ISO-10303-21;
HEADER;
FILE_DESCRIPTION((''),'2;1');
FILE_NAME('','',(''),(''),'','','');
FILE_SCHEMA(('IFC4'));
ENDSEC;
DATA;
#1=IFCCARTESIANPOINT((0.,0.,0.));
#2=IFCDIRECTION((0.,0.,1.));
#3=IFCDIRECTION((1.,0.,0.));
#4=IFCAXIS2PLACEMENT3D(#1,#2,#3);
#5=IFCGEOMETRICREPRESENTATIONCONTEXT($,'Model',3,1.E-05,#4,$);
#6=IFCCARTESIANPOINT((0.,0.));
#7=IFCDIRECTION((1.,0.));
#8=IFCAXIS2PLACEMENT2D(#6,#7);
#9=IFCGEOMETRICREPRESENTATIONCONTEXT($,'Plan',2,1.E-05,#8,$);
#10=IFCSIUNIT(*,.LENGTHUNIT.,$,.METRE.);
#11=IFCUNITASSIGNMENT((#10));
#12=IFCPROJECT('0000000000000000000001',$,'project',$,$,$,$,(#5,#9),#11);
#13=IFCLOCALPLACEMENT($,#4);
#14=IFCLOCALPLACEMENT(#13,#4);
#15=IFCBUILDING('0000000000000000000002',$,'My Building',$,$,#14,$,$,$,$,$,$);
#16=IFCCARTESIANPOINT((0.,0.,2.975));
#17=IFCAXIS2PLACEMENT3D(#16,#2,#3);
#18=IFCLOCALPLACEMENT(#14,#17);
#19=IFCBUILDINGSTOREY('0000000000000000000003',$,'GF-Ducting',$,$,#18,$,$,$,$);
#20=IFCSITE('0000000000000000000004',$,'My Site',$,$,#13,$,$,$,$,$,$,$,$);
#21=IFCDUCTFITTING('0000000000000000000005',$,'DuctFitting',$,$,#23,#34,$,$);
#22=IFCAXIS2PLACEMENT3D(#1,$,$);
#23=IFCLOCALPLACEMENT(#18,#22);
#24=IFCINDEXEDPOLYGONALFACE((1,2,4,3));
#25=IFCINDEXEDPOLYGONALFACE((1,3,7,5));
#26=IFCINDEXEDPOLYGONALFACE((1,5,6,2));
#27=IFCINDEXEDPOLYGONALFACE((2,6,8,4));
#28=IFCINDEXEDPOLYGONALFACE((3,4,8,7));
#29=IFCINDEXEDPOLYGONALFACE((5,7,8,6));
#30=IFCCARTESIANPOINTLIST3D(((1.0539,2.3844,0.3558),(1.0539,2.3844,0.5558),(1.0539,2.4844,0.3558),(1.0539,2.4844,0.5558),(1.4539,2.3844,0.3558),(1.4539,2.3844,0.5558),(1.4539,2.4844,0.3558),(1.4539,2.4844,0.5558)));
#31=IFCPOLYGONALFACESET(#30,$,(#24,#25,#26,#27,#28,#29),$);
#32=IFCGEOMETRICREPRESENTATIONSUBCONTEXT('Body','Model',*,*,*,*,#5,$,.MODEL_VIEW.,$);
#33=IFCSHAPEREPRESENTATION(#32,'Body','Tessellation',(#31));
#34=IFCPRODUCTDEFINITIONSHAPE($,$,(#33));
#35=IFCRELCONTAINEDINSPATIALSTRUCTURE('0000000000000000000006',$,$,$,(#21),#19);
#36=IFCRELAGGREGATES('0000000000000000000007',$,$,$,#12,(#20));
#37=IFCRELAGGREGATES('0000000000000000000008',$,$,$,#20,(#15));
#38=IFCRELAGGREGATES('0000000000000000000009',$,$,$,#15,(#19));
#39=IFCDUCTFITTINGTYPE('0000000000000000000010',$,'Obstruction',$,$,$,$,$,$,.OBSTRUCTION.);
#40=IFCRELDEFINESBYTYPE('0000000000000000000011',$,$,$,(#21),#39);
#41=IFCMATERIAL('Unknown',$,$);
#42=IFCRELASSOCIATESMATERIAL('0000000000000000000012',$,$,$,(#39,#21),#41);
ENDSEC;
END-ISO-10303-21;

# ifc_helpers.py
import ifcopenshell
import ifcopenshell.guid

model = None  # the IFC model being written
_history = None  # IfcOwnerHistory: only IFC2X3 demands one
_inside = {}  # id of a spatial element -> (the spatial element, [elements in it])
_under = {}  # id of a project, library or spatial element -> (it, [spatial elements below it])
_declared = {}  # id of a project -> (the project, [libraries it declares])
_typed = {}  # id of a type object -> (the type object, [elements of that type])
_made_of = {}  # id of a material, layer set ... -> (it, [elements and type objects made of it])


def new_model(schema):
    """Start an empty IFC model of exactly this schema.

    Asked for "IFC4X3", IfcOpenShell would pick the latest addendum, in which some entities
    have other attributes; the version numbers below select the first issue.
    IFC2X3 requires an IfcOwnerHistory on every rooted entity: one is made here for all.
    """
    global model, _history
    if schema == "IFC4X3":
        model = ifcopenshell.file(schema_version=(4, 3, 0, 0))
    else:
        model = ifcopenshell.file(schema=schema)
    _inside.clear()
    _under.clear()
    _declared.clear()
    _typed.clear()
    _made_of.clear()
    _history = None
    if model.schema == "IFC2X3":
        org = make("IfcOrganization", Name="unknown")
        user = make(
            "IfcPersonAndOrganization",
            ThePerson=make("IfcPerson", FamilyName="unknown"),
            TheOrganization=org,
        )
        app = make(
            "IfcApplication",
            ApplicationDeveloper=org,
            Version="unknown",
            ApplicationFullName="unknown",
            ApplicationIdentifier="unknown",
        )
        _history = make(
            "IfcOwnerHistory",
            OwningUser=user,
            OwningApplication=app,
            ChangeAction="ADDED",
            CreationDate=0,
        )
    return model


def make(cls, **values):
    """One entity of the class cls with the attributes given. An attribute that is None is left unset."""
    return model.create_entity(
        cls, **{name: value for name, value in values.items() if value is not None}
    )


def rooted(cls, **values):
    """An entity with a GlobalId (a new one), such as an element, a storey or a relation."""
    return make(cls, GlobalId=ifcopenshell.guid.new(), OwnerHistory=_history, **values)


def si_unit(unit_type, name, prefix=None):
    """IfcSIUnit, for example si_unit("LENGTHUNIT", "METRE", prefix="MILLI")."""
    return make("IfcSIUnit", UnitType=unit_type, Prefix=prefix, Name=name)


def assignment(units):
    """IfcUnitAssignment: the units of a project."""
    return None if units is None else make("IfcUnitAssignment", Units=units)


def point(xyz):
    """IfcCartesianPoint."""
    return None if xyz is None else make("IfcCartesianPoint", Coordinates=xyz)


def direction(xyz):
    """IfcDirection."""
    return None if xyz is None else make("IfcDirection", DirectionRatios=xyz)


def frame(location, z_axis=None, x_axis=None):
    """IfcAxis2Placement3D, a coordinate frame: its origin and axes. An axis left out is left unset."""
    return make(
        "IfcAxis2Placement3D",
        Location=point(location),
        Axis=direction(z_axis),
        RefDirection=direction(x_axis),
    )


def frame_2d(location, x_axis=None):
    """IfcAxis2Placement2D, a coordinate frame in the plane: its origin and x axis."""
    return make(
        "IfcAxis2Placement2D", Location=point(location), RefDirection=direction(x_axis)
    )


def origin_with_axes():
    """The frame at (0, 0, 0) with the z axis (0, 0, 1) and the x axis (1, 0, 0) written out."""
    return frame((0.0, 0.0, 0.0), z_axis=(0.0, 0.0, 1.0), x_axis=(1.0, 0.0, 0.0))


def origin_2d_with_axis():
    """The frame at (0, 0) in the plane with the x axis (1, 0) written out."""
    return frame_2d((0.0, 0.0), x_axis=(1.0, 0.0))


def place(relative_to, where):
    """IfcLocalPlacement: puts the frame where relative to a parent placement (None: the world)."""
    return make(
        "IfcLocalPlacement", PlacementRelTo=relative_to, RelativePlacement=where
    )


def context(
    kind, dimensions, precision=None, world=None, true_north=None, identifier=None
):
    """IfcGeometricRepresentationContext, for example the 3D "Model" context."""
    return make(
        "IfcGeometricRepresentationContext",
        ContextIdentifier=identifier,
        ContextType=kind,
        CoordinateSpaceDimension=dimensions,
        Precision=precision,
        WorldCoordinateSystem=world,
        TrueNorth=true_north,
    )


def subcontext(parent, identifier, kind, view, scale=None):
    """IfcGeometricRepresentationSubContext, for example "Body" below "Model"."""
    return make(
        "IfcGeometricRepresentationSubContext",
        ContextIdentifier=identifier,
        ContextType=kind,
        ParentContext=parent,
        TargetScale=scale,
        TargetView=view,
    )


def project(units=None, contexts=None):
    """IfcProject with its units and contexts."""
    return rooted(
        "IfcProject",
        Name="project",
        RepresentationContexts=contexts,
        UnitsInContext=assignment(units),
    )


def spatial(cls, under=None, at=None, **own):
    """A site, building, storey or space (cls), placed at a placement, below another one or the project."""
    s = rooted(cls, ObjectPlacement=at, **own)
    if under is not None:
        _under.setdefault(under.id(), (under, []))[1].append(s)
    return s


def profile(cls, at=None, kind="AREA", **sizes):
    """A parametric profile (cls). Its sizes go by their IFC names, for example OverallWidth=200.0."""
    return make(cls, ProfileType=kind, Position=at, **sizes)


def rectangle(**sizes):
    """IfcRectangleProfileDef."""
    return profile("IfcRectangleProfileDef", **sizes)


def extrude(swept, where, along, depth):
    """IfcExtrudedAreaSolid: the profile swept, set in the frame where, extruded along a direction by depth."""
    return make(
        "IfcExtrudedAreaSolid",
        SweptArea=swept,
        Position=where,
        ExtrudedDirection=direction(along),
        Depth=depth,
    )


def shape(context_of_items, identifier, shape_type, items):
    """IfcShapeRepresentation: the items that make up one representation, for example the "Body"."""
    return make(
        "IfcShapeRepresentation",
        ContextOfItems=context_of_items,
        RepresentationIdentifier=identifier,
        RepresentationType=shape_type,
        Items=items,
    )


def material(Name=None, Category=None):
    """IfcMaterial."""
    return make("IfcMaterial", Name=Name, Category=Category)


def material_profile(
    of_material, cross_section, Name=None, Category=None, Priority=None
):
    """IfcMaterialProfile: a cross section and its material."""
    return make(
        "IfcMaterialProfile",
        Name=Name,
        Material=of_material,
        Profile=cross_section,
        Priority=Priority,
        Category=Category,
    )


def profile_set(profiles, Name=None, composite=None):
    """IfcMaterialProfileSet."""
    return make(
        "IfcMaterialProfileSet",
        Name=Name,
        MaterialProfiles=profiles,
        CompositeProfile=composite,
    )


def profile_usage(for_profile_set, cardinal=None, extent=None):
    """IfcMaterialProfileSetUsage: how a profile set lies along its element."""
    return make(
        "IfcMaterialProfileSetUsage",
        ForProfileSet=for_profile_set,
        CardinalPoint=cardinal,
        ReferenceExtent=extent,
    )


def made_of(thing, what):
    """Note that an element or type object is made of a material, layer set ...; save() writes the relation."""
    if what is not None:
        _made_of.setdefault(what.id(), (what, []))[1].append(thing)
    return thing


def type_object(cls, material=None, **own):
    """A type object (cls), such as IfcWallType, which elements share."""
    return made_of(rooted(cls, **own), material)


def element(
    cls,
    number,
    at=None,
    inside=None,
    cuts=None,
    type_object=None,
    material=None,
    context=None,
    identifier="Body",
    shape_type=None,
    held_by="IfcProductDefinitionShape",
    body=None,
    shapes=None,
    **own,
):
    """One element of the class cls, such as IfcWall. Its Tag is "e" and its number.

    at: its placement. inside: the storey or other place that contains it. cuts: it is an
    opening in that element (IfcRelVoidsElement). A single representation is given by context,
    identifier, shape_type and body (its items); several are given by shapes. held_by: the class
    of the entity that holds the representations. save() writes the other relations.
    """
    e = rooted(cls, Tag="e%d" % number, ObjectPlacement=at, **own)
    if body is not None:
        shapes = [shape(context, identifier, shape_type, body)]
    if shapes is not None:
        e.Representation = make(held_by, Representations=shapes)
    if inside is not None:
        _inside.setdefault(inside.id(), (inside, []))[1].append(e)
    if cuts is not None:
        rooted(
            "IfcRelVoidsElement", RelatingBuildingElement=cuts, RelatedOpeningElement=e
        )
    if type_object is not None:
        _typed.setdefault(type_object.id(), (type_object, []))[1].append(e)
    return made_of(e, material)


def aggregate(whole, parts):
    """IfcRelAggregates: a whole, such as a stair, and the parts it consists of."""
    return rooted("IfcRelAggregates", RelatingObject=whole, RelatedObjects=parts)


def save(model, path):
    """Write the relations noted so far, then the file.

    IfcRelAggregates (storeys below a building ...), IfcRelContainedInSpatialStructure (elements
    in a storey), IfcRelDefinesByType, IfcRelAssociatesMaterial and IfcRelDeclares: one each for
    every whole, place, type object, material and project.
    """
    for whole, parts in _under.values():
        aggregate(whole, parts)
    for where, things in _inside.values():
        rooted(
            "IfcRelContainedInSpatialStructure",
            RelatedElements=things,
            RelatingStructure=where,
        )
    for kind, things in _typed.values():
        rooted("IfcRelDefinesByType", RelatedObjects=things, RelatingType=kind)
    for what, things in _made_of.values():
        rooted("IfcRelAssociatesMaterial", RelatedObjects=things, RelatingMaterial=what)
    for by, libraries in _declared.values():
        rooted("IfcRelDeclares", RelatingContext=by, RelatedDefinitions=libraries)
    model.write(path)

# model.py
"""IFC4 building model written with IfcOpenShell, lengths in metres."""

from ifc_helpers import new_model, si_unit, frame, origin_with_axes, origin_2d_with_axis, place, context, subcontext, project, spatial, rectangle, extrude, material, material_profile, profile_set, profile_usage, type_object, element, save


model = new_model("IFC4")

# Units and contexts
model_context = context("Model", 3, precision=1e-05, world=origin_with_axes())
plan_context = context("Plan", 2, precision=1e-05, world=origin_2d_with_axis())
body_context = subcontext(model_context, "Body", "Model", "MODEL_VIEW")
ifc_project = project(units=[si_unit("LENGTHUNIT", "METRE")], contexts=[model_context, plan_context])

# Site, building, storey
site_placement = place(None, origin_with_axes())
site = spatial("IfcSite", under=ifc_project, at=site_placement, Name="My Site")
building_placement = place(site_placement, origin_with_axes())
building = spatial("IfcBuilding", under=site, at=building_placement, Name="My Building")
storey_placement = place(building_placement, frame((0.0, 0.0, 2.975), z_axis=(0.0, 0.0, 1.0), x_axis=(1.0, 0.0, 0.0)))
storey = spatial("IfcBuildingStorey", under=building, at=storey_placement, Name="GF-Ducting")

# Shared definitions
ifc_material = material(Name="Unknown")

# Duct fitting
ifc_material_profile_1 = material_profile(ifc_material, rectangle(XDim=0.4, YDim=0.2))
ifc_profile_set_1 = profile_set([ifc_material_profile_1])
duct_fitting_type = type_object("IfcDuctFittingType", Name="Obstruction", PredefinedType="OBSTRUCTION", material=ifc_profile_set_1)
ifc_profile_usage_1 = profile_usage(ifc_profile_set_1, cardinal=5)
duct_fitting_1_placement = place(storey_placement, frame((1.2539, 2.4844, 0.4558), z_axis=(0.0, -1.0, 0.0), x_axis=(1.0, 0.0, 0.0)))
element("IfcDuctFitting", 1, at=duct_fitting_1_placement, inside=storey, type_object=duct_fitting_type, material=ifc_profile_usage_1, Name="DuctFitting", context=body_context, shape_type="SweptSolid", body=[
    extrude(rectangle(XDim=0.4, YDim=0.2), origin_with_axes(), (0.0, 0.0, 1.0), 0.1),
])

save(model, "model.ifc")
